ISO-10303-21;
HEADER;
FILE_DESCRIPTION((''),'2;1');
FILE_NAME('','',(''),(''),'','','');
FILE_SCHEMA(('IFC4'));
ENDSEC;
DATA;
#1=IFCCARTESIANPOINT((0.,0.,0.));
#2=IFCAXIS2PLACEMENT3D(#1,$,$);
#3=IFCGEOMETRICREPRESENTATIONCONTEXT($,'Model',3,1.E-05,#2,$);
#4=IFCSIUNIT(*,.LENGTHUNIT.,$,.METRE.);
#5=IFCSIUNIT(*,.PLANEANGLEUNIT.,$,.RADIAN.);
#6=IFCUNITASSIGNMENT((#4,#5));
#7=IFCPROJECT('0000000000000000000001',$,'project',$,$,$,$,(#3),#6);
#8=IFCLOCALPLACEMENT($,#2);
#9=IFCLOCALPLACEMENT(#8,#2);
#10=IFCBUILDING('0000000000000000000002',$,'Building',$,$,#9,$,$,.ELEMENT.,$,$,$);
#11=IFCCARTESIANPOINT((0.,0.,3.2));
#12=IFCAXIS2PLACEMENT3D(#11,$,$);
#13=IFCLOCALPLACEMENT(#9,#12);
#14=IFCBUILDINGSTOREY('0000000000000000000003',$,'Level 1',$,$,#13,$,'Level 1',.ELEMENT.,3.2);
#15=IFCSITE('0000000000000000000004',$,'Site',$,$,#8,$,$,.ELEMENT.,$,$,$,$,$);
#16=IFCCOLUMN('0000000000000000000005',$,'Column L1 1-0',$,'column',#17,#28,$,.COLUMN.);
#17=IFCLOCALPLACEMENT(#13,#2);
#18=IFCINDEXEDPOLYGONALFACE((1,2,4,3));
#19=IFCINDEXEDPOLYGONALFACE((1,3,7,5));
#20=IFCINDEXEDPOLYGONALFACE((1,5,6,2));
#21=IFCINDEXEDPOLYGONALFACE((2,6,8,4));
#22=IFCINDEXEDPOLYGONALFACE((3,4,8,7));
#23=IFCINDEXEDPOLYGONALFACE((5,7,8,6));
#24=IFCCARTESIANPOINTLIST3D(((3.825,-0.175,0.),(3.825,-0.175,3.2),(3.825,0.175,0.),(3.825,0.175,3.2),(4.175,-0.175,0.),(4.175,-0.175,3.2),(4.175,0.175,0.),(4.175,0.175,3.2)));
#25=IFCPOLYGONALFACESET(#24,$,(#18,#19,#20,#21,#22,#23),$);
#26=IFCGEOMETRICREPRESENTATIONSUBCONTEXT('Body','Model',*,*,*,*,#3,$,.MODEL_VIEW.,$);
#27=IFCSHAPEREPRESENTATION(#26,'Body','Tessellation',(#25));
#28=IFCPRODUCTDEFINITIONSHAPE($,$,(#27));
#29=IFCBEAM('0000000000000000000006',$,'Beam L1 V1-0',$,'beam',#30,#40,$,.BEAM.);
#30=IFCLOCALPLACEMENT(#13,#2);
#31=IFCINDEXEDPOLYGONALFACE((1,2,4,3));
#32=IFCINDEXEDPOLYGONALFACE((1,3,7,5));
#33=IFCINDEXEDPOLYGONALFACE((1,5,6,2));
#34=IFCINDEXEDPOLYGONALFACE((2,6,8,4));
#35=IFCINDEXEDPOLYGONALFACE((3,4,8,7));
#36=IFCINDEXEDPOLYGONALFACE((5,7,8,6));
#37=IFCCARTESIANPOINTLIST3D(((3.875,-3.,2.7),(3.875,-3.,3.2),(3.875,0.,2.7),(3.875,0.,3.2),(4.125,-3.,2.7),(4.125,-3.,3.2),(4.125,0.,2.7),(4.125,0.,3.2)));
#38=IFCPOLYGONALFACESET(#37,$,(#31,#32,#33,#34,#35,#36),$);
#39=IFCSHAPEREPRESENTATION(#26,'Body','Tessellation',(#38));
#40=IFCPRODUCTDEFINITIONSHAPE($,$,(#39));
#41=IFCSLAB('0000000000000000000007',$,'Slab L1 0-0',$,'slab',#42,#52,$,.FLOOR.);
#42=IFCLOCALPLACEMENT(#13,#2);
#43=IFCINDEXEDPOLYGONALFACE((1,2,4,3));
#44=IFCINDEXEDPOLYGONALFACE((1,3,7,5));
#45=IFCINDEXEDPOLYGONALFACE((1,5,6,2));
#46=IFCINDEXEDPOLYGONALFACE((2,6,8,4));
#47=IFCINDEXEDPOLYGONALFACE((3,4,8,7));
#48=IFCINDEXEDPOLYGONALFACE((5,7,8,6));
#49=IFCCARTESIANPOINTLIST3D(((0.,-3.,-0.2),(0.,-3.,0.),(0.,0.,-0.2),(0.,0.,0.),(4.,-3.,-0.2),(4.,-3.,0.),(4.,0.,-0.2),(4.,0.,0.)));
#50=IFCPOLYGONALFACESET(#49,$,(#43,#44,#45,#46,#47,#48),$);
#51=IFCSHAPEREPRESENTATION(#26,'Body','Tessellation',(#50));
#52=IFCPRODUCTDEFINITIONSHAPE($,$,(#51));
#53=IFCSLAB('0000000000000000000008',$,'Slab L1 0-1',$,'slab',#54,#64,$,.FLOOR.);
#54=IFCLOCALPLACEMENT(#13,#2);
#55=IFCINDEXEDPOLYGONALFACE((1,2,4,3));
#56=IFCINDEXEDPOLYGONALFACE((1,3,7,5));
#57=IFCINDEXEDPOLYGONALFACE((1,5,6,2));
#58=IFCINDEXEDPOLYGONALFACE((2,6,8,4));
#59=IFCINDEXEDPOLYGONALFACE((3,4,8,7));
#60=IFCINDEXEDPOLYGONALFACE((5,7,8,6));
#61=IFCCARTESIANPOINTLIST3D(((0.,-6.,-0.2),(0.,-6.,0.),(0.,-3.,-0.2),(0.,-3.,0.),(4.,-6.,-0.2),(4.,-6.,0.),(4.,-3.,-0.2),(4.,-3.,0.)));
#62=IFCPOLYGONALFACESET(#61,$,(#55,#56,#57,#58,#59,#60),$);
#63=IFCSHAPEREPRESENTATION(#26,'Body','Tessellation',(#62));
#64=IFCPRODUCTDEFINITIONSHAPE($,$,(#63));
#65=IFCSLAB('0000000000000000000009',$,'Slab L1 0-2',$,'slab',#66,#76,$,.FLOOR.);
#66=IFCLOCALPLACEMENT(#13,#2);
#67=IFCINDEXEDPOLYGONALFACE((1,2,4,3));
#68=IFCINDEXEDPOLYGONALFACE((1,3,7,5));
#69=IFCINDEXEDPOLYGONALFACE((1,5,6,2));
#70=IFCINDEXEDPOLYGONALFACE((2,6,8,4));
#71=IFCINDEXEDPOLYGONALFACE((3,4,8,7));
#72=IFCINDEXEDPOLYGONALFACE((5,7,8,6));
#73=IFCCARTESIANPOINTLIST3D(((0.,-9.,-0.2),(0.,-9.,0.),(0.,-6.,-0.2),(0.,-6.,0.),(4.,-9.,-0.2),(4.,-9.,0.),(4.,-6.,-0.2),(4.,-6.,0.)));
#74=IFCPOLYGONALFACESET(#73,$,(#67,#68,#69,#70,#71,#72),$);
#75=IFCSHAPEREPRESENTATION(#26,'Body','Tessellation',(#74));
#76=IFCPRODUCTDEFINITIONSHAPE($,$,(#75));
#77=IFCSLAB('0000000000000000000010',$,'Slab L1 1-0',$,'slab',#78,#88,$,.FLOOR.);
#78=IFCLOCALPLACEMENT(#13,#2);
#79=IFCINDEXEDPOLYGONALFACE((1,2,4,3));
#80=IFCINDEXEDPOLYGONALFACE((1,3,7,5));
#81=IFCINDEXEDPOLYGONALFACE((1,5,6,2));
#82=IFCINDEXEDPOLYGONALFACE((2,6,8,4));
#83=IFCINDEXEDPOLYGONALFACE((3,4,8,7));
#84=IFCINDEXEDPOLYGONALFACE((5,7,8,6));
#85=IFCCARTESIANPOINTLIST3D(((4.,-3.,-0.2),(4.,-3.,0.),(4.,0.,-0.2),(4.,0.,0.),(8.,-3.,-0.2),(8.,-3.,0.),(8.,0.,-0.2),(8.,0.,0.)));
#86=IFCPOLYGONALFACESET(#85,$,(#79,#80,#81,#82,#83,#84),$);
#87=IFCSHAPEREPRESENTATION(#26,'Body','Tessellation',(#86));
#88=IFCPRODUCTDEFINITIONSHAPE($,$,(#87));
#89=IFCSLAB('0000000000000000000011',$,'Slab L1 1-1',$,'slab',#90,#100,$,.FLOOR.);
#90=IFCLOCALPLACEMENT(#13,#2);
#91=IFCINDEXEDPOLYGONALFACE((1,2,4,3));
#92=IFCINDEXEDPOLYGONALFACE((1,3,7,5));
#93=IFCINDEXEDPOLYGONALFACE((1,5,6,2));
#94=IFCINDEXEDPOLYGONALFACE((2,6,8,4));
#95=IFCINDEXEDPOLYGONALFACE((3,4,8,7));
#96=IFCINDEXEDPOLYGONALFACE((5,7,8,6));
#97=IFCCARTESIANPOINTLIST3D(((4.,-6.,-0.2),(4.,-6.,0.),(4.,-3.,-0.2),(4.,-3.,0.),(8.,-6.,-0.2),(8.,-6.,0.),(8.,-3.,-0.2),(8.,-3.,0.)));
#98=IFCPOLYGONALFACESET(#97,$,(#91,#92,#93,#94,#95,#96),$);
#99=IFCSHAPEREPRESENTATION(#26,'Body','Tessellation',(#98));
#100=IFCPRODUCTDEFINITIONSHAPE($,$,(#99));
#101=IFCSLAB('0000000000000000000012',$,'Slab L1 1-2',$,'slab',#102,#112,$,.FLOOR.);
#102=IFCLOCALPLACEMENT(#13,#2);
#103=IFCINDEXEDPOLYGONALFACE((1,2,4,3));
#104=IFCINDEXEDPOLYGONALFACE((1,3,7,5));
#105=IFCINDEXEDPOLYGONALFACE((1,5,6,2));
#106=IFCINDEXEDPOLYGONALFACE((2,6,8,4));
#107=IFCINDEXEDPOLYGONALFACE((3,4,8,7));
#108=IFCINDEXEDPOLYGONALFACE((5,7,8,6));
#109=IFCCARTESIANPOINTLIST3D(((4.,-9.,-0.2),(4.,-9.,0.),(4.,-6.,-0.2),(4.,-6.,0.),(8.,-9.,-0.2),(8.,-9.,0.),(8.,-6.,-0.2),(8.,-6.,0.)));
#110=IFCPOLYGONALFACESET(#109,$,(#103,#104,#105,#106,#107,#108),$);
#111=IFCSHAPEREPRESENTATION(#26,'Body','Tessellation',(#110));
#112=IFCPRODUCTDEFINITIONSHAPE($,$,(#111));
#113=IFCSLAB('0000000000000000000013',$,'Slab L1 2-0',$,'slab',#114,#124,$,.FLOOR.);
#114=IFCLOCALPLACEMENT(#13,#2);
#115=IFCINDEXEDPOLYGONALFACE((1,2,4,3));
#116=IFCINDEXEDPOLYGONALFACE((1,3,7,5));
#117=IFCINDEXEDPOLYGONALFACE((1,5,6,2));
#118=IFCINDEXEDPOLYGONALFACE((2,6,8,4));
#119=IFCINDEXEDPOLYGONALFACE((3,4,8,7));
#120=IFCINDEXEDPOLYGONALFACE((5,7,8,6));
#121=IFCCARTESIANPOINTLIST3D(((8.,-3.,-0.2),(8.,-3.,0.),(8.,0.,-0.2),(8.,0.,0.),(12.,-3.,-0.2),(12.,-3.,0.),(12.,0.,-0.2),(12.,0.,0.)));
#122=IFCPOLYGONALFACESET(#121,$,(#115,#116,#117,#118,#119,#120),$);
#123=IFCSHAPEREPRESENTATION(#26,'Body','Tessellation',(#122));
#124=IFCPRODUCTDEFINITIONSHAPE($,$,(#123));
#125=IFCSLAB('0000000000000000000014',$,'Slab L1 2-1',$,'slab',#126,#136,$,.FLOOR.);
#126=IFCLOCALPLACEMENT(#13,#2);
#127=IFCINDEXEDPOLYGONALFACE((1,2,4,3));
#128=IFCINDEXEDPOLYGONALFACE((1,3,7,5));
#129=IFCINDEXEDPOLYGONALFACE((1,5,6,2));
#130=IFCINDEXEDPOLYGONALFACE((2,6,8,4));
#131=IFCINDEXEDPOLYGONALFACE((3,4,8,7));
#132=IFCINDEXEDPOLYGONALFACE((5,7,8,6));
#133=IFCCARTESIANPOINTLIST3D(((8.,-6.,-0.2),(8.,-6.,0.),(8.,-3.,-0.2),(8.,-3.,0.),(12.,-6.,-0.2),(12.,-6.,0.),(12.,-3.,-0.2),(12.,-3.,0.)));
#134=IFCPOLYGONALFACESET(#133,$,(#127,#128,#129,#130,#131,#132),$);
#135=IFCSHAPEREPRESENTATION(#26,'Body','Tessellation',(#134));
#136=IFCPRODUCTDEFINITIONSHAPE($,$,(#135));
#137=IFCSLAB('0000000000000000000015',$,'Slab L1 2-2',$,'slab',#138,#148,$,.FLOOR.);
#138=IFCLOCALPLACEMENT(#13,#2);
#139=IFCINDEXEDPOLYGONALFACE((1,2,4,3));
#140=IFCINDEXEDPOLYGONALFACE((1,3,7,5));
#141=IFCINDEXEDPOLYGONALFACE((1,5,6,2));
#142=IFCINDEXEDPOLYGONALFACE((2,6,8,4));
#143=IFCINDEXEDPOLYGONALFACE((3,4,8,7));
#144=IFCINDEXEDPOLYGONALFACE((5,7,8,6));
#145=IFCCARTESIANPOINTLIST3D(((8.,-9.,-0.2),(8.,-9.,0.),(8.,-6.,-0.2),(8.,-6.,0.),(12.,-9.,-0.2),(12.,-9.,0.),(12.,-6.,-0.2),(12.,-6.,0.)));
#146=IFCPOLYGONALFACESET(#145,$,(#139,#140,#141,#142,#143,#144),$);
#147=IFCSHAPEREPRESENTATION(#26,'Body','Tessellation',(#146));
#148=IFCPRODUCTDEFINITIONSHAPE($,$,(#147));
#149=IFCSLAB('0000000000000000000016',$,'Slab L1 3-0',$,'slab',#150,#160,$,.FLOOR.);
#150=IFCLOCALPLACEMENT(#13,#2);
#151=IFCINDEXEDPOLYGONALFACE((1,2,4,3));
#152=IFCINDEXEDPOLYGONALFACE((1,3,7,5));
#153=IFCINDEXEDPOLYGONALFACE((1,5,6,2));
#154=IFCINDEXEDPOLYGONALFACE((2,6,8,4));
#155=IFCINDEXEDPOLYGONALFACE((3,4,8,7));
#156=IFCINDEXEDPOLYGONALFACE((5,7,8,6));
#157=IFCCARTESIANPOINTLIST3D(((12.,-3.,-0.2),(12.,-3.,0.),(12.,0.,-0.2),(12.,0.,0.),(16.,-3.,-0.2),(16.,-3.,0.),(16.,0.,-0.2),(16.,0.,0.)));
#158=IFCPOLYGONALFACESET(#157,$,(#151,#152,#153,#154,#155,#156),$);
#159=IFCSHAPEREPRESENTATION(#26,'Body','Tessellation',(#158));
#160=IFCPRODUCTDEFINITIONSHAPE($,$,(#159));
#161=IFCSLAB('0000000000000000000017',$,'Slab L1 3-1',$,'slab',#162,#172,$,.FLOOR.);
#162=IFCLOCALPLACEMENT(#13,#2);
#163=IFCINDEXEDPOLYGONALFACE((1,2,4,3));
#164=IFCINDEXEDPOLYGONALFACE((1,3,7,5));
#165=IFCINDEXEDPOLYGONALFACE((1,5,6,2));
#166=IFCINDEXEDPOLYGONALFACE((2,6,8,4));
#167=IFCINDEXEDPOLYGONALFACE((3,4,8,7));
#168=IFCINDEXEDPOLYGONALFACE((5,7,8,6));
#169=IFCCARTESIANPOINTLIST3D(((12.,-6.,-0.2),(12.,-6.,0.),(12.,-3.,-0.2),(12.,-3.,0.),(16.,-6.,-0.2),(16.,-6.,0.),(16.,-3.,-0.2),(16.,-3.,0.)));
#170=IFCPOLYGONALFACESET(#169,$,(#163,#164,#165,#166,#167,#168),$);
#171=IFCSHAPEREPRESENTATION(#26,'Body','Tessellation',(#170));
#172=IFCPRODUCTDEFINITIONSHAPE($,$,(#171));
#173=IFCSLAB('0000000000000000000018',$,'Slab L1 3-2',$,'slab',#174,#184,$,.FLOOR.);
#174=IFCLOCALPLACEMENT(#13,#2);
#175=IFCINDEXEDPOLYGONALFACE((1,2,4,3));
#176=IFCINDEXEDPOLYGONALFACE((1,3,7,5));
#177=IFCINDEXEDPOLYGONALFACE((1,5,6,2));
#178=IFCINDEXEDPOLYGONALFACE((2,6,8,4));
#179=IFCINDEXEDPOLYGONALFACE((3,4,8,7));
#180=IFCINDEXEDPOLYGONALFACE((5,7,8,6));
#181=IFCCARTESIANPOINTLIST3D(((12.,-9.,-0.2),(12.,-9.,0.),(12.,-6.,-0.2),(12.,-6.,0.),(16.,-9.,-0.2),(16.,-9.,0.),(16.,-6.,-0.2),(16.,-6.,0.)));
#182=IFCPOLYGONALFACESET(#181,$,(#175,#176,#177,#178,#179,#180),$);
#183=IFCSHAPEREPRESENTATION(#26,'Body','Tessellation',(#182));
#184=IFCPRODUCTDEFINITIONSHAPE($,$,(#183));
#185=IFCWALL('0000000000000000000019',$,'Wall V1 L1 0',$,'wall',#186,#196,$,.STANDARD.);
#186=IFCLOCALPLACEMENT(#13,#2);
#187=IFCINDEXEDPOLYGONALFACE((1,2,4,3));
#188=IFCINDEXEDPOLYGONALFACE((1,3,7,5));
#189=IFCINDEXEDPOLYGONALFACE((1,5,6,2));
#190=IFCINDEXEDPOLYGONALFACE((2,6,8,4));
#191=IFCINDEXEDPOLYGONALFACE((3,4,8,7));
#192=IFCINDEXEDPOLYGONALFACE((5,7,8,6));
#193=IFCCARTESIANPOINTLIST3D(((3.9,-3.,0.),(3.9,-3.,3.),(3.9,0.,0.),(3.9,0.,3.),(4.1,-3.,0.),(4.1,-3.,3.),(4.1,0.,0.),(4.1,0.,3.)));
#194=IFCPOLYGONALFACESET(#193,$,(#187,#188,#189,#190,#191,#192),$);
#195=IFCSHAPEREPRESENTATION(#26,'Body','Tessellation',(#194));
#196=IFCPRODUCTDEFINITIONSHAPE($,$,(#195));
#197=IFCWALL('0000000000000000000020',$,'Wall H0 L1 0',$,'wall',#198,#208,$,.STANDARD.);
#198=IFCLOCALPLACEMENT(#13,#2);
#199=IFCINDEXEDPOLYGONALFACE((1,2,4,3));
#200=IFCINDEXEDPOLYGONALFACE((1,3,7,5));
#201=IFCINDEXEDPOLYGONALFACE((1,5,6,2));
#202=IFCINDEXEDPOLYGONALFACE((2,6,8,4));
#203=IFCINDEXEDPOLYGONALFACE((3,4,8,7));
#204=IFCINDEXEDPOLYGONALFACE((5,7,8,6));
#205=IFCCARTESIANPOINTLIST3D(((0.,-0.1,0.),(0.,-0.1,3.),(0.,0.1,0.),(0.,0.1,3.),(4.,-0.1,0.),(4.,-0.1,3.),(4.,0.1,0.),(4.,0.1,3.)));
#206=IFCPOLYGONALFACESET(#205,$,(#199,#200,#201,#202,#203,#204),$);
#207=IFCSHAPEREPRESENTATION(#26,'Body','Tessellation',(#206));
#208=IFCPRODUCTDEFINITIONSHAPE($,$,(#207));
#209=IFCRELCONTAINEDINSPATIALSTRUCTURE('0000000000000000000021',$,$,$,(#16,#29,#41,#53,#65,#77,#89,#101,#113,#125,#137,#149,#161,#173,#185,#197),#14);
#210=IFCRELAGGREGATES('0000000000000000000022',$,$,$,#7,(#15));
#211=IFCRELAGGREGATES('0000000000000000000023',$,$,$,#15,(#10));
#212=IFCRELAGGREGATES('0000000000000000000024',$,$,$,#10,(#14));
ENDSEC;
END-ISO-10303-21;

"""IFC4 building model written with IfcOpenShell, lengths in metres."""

from ifc_helpers import new_model, si_unit, frame, frame_2d, origin, origin_with_axes, origin_2d, place, context, subcontext, project, spatial, polyline, rectangle, outline, extrude, element, save


model = new_model("IFC4")

# Units and contexts
model_context = context("Model", 3, precision=1e-05, world=origin())
body_context = subcontext(model_context, "Body", "Model", "MODEL_VIEW")
ifc_project = project(units=[si_unit("LENGTHUNIT", "METRE"), si_unit("PLANEANGLEUNIT", "RADIAN")], contexts=[model_context])

# Site, building, storey
site_placement = place(None, origin())
site = spatial("IfcSite", under=ifc_project, at=site_placement, Name="Site", CompositionType="ELEMENT")
building_placement = place(site_placement, origin())
building = spatial("IfcBuilding", under=site, at=building_placement, Name="Building", CompositionType="ELEMENT")
storey_placement = place(building_placement, frame((0.0, 0.0, 3.2)))
storey = spatial("IfcBuildingStorey", under=building, at=storey_placement, Name="Level 1", LongName="Level 1", CompositionType="ELEMENT", Elevation=3.2)

# Column
column_placement = place(storey_placement, frame((4.0, 0.0, 0.0)))
element("IfcColumn", 1, at=column_placement, inside=storey, Name="Column L1 1-0", ObjectType="column", PredefinedType="COLUMN", context=body_context, shape_type="SweptSolid", body=[
    extrude(rectangle(XDim=0.35, YDim=0.35, at=origin_2d()), origin(), (0.0, 0.0, 1.0), 3.2),
])

# Beam
beam_placement = place(storey_placement, frame((4.0, 0.0, 2.95), z_axis=(0.0, -1.0, 0.0), x_axis=(0.0, 0.0, 1.0)))
element("IfcBeam", 2, at=beam_placement, inside=storey, Name="Beam L1 V1-0", ObjectType="beam", PredefinedType="BEAM", context=body_context, shape_type="SweptSolid", body=[
    extrude(rectangle(XDim=0.5, YDim=0.25, at=origin_2d()), origin(), (0.0, 0.0, 1.0), 3.0),
])

# Slabs
slab_1_placement = place(storey_placement, frame((0.0, 0.0, -0.2)))
element("IfcSlab", 3, at=slab_1_placement, inside=storey, Name="Slab L1 0-0", ObjectType="slab", PredefinedType="FLOOR", context=body_context, shape_type="SweptSolid", body=[
    extrude(outline(polyline([(0.0, -3.0), (4.0, -3.0), (4.0, 0.0), (0.0, 0.0), (0.0, -3.0)])), origin(), (0.0, 0.0, 1.0), 0.2),
])
slab_2_placement = place(storey_placement, frame((0.0, 0.0, -0.2)))
element("IfcSlab", 4, at=slab_2_placement, inside=storey, Name="Slab L1 0-1", ObjectType="slab", PredefinedType="FLOOR", context=body_context, shape_type="SweptSolid", body=[
    extrude(outline(polyline([(0.0, -6.0), (4.0, -6.0), (4.0, -3.0), (0.0, -3.0), (0.0, -6.0)])), origin(), (0.0, 0.0, 1.0), 0.2),
])
slab_3_placement = place(storey_placement, frame((0.0, 0.0, -0.2)))
element("IfcSlab", 5, at=slab_3_placement, inside=storey, Name="Slab L1 0-2", ObjectType="slab", PredefinedType="FLOOR", context=body_context, shape_type="SweptSolid", body=[
    extrude(outline(polyline([(0.0, -9.0), (4.0, -9.0), (4.0, -6.0), (0.0, -6.0), (0.0, -9.0)])), origin(), (0.0, 0.0, 1.0), 0.2),
])
slab_4_placement = place(storey_placement, frame((0.0, 0.0, -0.2)))
element("IfcSlab", 6, at=slab_4_placement, inside=storey, Name="Slab L1 1-0", ObjectType="slab", PredefinedType="FLOOR", context=body_context, shape_type="SweptSolid", body=[
    extrude(outline(polyline([(4.0, -3.0), (8.0, -3.0), (8.0, 0.0), (4.0, 0.0), (4.0, -3.0)])), origin(), (0.0, 0.0, 1.0), 0.2),
])
slab_5_placement = place(storey_placement, frame((0.0, 0.0, -0.2)))
element("IfcSlab", 7, at=slab_5_placement, inside=storey, Name="Slab L1 1-1", ObjectType="slab", PredefinedType="FLOOR", context=body_context, shape_type="SweptSolid", body=[
    extrude(outline(polyline([(4.0, -6.0), (8.0, -6.0), (8.0, -3.0), (4.0, -3.0), (4.0, -6.0)])), origin(), (0.0, 0.0, 1.0), 0.2),
])
slab_6_placement = place(storey_placement, frame((0.0, 0.0, -0.2)))
element("IfcSlab", 8, at=slab_6_placement, inside=storey, Name="Slab L1 1-2", ObjectType="slab", PredefinedType="FLOOR", context=body_context, shape_type="SweptSolid", body=[
    extrude(outline(polyline([(4.0, -9.0), (8.0, -9.0), (8.0, -6.0), (4.0, -6.0), (4.0, -9.0)])), origin(), (0.0, 0.0, 1.0), 0.2),
])
slab_7_placement = place(storey_placement, frame((0.0, 0.0, -0.2)))
element("IfcSlab", 9, at=slab_7_placement, inside=storey, Name="Slab L1 2-0", ObjectType="slab", PredefinedType="FLOOR", context=body_context, shape_type="SweptSolid", body=[
    extrude(outline(polyline([(8.0, -3.0), (12.0, -3.0), (12.0, 0.0), (8.0, 0.0), (8.0, -3.0)])), origin(), (0.0, 0.0, 1.0), 0.2),
])
slab_8_placement = place(storey_placement, frame((0.0, 0.0, -0.2)))
element("IfcSlab", 10, at=slab_8_placement, inside=storey, Name="Slab L1 2-1", ObjectType="slab", PredefinedType="FLOOR", context=body_context, shape_type="SweptSolid", body=[
    extrude(outline(polyline([(8.0, -6.0), (12.0, -6.0), (12.0, -3.0), (8.0, -3.0), (8.0, -6.0)])), origin(), (0.0, 0.0, 1.0), 0.2),
])
slab_9_placement = place(storey_placement, frame((0.0, 0.0, -0.2)))
element("IfcSlab", 11, at=slab_9_placement, inside=storey, Name="Slab L1 2-2", ObjectType="slab", PredefinedType="FLOOR", context=body_context, shape_type="SweptSolid", body=[
    extrude(outline(polyline([(8.0, -9.0), (12.0, -9.0), (12.0, -6.0), (8.0, -6.0), (8.0, -9.0)])), origin(), (0.0, 0.0, 1.0), 0.2),
])
slab_10_placement = place(storey_placement, frame((0.0, 0.0, -0.2)))
element("IfcSlab", 12, at=slab_10_placement, inside=storey, Name="Slab L1 3-0", ObjectType="slab", PredefinedType="FLOOR", context=body_context, shape_type="SweptSolid", body=[
    extrude(outline(polyline([(12.0, -3.0), (16.0, -3.0), (16.0, 0.0), (12.0, 0.0), (12.0, -3.0)])), origin(), (0.0, 0.0, 1.0), 0.2),
])
slab_11_placement = place(storey_placement, frame((0.0, 0.0, -0.2)))
element("IfcSlab", 13, at=slab_11_placement, inside=storey, Name="Slab L1 3-1", ObjectType="slab", PredefinedType="FLOOR", context=body_context, shape_type="SweptSolid", body=[
    extrude(outline(polyline([(12.0, -6.0), (16.0, -6.0), (16.0, -3.0), (12.0, -3.0), (12.0, -6.0)])), origin(), (0.0, 0.0, 1.0), 0.2),
])
slab_12_placement = place(storey_placement, frame((0.0, 0.0, -0.2)))
element("IfcSlab", 14, at=slab_12_placement, inside=storey, Name="Slab L1 3-2", ObjectType="slab", PredefinedType="FLOOR", context=body_context, shape_type="SweptSolid", body=[
    extrude(outline(polyline([(12.0, -9.0), (16.0, -9.0), (16.0, -6.0), (12.0, -6.0), (12.0, -9.0)])), origin(), (0.0, 0.0, 1.0), 0.2),
])

# Walls
wall_1_placement = place(storey_placement, frame((4.0, 0.0, 0.0), z_axis=(0.0, 0.0, 1.0), x_axis=(0.0, -1.0, 0.0)))
element("IfcWall", 15, at=wall_1_placement, inside=storey, Name="Wall V1 L1 0", ObjectType="wall", PredefinedType="STANDARD", context=body_context, shape_type="SweptSolid", body=[
    extrude(rectangle(XDim=3.0, YDim=0.2, at=frame_2d((1.5, 0.0))), origin(), (0.0, 0.0, 1.0), 3.0),
])
wall_2_placement = place(storey_placement, origin_with_axes())
element("IfcWall", 16, at=wall_2_placement, inside=storey, Name="Wall H0 L1 0", ObjectType="wall", PredefinedType="STANDARD", context=body_context, shape_type="SweptSolid", body=[
    extrude(rectangle(XDim=4.0, YDim=0.2, at=frame_2d((2.0, 0.0))), origin(), (0.0, 0.0, 1.0), 3.0),
])

save(model, "model.ifc")
